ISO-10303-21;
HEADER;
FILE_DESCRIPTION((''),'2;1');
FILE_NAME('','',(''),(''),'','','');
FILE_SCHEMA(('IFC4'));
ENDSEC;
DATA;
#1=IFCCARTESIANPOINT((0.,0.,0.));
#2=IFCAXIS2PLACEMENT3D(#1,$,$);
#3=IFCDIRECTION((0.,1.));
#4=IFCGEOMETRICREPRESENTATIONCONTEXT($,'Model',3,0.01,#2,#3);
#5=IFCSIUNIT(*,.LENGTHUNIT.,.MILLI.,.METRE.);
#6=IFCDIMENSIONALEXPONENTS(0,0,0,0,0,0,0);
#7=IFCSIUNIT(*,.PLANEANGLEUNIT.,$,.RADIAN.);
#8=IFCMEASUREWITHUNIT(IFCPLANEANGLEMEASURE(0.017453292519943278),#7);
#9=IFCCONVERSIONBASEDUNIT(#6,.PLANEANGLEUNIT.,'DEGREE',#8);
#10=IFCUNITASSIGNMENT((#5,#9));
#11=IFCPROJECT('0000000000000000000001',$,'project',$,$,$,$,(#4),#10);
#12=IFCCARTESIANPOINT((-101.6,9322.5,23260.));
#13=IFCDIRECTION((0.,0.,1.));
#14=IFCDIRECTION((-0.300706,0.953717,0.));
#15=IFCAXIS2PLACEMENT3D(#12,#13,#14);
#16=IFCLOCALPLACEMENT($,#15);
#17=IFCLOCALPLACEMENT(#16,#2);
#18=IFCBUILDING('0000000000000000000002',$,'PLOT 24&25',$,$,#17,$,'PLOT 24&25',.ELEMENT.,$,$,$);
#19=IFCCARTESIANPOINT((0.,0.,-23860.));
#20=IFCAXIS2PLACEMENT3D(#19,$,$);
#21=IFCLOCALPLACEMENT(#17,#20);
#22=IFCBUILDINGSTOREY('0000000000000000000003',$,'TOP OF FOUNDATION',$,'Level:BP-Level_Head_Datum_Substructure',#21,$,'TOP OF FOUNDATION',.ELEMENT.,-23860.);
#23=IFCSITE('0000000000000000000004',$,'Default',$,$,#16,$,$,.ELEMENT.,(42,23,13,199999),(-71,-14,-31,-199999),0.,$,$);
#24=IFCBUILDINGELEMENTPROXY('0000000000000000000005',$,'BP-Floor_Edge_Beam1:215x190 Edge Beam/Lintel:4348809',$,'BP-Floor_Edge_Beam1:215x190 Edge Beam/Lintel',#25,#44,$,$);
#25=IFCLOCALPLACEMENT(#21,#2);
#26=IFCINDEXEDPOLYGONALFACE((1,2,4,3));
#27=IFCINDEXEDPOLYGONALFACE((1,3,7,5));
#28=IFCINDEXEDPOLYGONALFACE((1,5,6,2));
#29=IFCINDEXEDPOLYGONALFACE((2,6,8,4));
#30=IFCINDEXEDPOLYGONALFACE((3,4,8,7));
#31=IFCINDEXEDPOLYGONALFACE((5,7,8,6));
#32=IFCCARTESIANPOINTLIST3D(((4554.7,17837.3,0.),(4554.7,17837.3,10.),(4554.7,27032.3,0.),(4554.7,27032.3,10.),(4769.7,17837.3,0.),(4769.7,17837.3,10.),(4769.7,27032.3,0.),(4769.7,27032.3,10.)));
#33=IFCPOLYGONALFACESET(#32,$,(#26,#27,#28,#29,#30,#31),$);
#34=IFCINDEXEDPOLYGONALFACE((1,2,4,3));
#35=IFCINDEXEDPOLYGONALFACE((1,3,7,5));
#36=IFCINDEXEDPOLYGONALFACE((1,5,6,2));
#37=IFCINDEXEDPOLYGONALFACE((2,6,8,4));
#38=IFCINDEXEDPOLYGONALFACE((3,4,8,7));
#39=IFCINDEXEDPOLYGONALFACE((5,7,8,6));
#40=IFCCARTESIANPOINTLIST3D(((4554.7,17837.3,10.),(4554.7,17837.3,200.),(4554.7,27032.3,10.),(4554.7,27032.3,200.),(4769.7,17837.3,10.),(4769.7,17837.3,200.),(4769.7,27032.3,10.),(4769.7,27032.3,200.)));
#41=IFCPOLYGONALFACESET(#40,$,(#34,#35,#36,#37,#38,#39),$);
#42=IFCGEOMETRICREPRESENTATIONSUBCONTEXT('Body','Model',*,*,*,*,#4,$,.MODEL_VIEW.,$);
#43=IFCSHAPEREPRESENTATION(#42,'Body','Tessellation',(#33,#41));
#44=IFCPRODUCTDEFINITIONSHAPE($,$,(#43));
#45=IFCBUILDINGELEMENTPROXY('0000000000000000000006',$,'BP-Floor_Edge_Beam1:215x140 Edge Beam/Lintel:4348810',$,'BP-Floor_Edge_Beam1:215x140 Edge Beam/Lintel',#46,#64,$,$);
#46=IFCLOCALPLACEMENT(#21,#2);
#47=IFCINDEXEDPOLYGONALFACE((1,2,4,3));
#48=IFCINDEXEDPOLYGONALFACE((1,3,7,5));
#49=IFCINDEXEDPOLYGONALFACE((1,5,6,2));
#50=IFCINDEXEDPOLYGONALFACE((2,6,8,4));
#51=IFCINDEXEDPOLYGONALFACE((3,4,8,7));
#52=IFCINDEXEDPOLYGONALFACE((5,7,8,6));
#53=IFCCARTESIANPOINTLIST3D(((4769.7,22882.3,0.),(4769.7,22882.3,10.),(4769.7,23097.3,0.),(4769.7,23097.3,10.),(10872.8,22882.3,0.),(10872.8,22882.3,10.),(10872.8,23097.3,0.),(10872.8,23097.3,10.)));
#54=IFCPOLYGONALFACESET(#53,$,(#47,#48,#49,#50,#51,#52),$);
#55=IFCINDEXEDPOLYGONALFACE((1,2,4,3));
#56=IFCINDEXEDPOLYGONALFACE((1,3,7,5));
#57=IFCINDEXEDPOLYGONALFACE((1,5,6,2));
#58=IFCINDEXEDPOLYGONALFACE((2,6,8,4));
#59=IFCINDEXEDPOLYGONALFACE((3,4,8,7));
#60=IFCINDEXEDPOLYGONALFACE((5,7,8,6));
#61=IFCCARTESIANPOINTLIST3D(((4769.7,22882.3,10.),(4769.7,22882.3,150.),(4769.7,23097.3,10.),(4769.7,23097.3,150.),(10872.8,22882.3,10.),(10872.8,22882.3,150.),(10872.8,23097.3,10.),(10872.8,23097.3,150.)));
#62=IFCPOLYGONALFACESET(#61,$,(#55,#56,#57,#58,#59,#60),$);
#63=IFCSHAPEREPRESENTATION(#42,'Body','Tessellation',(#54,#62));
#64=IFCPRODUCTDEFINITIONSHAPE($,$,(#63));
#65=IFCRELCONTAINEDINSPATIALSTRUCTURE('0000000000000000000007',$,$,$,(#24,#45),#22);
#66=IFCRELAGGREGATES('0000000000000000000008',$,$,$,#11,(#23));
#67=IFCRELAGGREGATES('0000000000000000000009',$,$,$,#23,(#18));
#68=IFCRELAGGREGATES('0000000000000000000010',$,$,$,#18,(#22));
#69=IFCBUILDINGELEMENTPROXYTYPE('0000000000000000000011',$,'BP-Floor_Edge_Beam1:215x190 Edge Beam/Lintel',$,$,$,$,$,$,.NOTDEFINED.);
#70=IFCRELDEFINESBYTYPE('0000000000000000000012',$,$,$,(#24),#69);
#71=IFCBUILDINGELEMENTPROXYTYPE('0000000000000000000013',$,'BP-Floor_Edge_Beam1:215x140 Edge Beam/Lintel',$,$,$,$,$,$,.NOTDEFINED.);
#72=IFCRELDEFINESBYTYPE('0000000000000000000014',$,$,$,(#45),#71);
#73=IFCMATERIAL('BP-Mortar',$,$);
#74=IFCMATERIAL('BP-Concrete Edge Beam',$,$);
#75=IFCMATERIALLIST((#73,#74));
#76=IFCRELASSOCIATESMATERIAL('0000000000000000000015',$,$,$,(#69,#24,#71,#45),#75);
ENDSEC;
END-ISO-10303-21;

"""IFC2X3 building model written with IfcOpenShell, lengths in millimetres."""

from ifc_helpers import new_model, entity, si_unit, converted_unit, direction, frame, origin, origin_2d_with_axis, place, context, subcontext, project, spatial, rectangle, extrude, source, transform, mapped, material, material_list, type_object, type_shapes, element, save


model = new_model("IFC2X3")

# Units and contexts
model_context = context("Model", 3, precision=0.01, world=origin(), true_north=direction((0.0, 1.0)))
body_context = subcontext(model_context, "Body", "Model", "MODEL_VIEW")
ifc_project = project(units=[si_unit("LENGTHUNIT", "METRE", prefix="MILLI"), converted_unit("PLANEANGLEUNIT", "DEGREE", entity("IfcPlaneAngleMeasure", 0.017453292519943278), si_unit("PLANEANGLEUNIT", "RADIAN"), dimensions=[0, 0, 0, 0, 0, 0, 0])], contexts=[model_context])

# Site, building, storey
site_placement = place(None, frame((-101.6, 9322.5, 23260.0), z_axis=(0.0, 0.0, 1.0), x_axis=(-0.300706, 0.953717, 0.0)))
site = spatial("IfcSite", under=ifc_project, at=site_placement, Name="Default", CompositionType="ELEMENT", RefLatitude=(42, 23, 13, 199999), RefLongitude=(-71, -14, -31, -199999), RefElevation=0.0)
building_placement = place(site_placement, origin())
building = spatial("IfcBuilding", under=site, at=building_placement, Name="PLOT 24&25", LongName="PLOT 24&25", CompositionType="ELEMENT")
storey_placement = place(building_placement, frame((0.0, 0.0, -23860.0)))
storey = spatial("IfcBuildingStorey", under=building, at=storey_placement, Name="TOP OF FOUNDATION", ObjectType="Level:BP-Level_Head_Datum_Substructure", LongName="TOP OF FOUNDATION", CompositionType="ELEMENT", Elevation=-23860.0)

# Building element proxies
ifc_material_1 = material(Name="BP-Mortar")
ifc_material_2 = material(Name="BP-Concrete Edge Beam")
ifc_material_list = material_list([ifc_material_1, ifc_material_2])
building_element_proxy_type_1 = type_object("IfcBuildingElementProxyType", Name="BP-Floor_Edge_Beam1:215x190 Edge Beam/Lintel", PredefinedType="NOTDEFINED", material=ifc_material_list)
shared_shape_1 = source(origin(), body_context, "Body", "SweptSolid", [
    extrude(rectangle(XDim=215.0, YDim=9195.0, at=origin_2d_with_axis()), frame((0.0, 0.0, 0.0), z_axis=(0.0, 0.0, 1.0), x_axis=(0.0, 1.0, 0.0)), (0.0, 0.0, 1.0), 10.0),
    extrude(rectangle(XDim=215.0, YDim=9195.0, at=origin_2d_with_axis()), frame((0.0, 0.0, 10.0), z_axis=(0.0, 0.0, 1.0), x_axis=(0.0, 1.0, 0.0)), (0.0, 0.0, 1.0), 190.0),
])
type_shapes(building_element_proxy_type_1, [shared_shape_1])
proxy_1_placement = place(storey_placement, frame((4662.2, 22434.8, 0.0), z_axis=(0.0, 0.0, 1.0), x_axis=(0.0, 1.0, 0.0)))
element("IfcBuildingElementProxy", 1, at=proxy_1_placement, inside=storey, type_object=building_element_proxy_type_1, material=ifc_material_list, Name="BP-Floor_Edge_Beam1:215x190 Edge Beam/Lintel:4348809", ObjectType="BP-Floor_Edge_Beam1:215x190 Edge Beam/Lintel", context=body_context, shape_type="MappedRepresentation", body=[
    mapped(shared_shape_1, transform((0.0, 0.0, 0.0), scale=1.0)),
])
building_element_proxy_type_2 = type_object("IfcBuildingElementProxyType", Name="BP-Floor_Edge_Beam1:215x140 Edge Beam/Lintel", PredefinedType="NOTDEFINED", material=ifc_material_list)
shared_shape_2 = source(origin(), body_context, "Body", "SweptSolid", [
    extrude(rectangle(XDim=6103.2, YDim=215.0, at=origin_2d_with_axis()), frame((0.0, 0.0, 0.0), z_axis=(0.0, 0.0, 1.0), x_axis=(-1.0, 0.0, 0.0)), (0.0, 0.0, 1.0), 10.0),
    extrude(rectangle(XDim=6103.2, YDim=215.0, at=origin_2d_with_axis()), frame((0.0, 0.0, 10.0), z_axis=(0.0, 0.0, 1.0), x_axis=(-1.0, 0.0, 0.0)), (0.0, 0.0, 1.0), 140.0),
])
type_shapes(building_element_proxy_type_2, [shared_shape_2])
proxy_2_placement = place(storey_placement, frame((7821.3, 22989.8, 0.0), z_axis=(0.0, 0.0, 1.0), x_axis=(-1.0, 0.0, 0.0)))
element("IfcBuildingElementProxy", 2, at=proxy_2_placement, inside=storey, type_object=building_element_proxy_type_2, material=ifc_material_list, Name="BP-Floor_Edge_Beam1:215x140 Edge Beam/Lintel:4348810", ObjectType="BP-Floor_Edge_Beam1:215x140 Edge Beam/Lintel", context=body_context, shape_type="MappedRepresentation", body=[
    mapped(shared_shape_2, transform((0.0, 0.0, 0.0), scale=1.0)),
])

save(model, "model.ifc")
